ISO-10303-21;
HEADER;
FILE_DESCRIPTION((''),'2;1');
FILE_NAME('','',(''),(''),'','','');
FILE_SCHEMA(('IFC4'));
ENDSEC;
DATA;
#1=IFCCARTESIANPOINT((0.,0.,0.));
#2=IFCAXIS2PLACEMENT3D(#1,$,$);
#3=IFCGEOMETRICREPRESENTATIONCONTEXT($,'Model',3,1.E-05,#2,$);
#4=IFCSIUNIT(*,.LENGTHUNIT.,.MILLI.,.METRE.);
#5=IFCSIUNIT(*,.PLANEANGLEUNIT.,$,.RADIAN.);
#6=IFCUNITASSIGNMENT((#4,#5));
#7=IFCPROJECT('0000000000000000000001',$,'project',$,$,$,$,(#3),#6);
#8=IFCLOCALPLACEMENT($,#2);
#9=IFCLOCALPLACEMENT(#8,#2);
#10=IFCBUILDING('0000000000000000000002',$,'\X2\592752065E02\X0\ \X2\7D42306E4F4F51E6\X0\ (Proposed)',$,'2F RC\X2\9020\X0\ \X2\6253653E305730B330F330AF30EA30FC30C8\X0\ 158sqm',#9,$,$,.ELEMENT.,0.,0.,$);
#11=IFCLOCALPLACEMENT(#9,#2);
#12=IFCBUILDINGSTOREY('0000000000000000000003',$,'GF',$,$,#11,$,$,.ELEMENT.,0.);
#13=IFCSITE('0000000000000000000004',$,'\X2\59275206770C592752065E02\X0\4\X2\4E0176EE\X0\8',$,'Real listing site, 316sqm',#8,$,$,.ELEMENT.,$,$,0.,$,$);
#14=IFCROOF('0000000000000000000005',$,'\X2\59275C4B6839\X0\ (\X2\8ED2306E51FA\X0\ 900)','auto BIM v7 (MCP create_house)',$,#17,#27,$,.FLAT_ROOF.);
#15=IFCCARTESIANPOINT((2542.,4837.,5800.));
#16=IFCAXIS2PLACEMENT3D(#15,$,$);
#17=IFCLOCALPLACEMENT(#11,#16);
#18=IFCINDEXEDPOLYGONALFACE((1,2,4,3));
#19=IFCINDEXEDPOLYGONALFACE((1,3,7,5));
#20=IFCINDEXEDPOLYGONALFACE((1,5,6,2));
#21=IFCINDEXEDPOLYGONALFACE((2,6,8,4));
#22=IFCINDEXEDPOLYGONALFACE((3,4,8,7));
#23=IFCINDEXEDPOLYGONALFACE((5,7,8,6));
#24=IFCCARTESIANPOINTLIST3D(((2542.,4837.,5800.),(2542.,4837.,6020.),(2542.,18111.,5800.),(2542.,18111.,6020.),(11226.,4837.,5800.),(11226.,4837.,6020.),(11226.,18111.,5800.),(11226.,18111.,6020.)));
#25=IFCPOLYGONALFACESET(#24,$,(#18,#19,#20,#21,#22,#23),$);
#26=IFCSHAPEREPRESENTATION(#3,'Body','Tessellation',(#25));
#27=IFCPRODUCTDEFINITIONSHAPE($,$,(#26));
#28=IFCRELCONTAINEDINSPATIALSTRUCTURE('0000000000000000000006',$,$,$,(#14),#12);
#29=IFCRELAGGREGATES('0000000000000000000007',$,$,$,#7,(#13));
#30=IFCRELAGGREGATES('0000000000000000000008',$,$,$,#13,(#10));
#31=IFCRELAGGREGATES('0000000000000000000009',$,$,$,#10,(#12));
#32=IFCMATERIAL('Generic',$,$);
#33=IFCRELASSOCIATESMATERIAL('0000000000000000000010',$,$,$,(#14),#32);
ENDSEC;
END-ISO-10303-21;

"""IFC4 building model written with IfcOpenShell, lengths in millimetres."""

from ifc_helpers import new_model, si_unit, frame, frame_2d, origin, place, context, project, spatial, rectangle, extrude, material, element, save


model = new_model("IFC4")

# Units and contexts
model_context = context("Model", 3, precision=1e-05, world=origin())
ifc_project = project(units=[si_unit("LENGTHUNIT", "METRE", prefix="MILLI"), si_unit("PLANEANGLEUNIT", "RADIAN")], contexts=[model_context])

# Site, building, storey
site_placement = place(None, origin())
site = spatial("IfcSite", under=ifc_project, at=site_placement, Name="大分県大分市4丁目8", ObjectType="Real listing site, 316sqm", CompositionType="ELEMENT", RefElevation=0.0)
building_placement = place(site_placement, origin())
building = spatial("IfcBuilding", under=site, at=building_placement, Name="大分市 終の住処 (Proposed)", ObjectType="2F RC造 打放しコンクリート 158sqm", CompositionType="ELEMENT", ElevationOfRefHeight=0.0, ElevationOfTerrain=0.0)
storey_placement = place(building_placement, origin())
storey = spatial("IfcBuildingStorey", under=building, at=storey_placement, Name="GF", CompositionType="ELEMENT", Elevation=0.0)

# Shared definitions
ifc_material = material(Name="Generic")

# Roof
roof_placement = place(storey_placement, frame((2542.0, 4837.0, 5800.0)))
element("IfcRoof", 1, at=roof_placement, inside=storey, material=ifc_material, Name="大屋根 (軒の出 900)", Description="auto BIM v7 (MCP create_house)", PredefinedType="FLAT_ROOF", context=model_context, shape_type="SweptSolid", body=[
    extrude(rectangle(XDim=8684.0, YDim=13274.0, at=frame_2d((4342.0, 6637.0))), frame((2542.0, 4837.0, 5800.0)), (0.0, 0.0, 1.0), 220.0),
])

save(model, "model.ifc")
